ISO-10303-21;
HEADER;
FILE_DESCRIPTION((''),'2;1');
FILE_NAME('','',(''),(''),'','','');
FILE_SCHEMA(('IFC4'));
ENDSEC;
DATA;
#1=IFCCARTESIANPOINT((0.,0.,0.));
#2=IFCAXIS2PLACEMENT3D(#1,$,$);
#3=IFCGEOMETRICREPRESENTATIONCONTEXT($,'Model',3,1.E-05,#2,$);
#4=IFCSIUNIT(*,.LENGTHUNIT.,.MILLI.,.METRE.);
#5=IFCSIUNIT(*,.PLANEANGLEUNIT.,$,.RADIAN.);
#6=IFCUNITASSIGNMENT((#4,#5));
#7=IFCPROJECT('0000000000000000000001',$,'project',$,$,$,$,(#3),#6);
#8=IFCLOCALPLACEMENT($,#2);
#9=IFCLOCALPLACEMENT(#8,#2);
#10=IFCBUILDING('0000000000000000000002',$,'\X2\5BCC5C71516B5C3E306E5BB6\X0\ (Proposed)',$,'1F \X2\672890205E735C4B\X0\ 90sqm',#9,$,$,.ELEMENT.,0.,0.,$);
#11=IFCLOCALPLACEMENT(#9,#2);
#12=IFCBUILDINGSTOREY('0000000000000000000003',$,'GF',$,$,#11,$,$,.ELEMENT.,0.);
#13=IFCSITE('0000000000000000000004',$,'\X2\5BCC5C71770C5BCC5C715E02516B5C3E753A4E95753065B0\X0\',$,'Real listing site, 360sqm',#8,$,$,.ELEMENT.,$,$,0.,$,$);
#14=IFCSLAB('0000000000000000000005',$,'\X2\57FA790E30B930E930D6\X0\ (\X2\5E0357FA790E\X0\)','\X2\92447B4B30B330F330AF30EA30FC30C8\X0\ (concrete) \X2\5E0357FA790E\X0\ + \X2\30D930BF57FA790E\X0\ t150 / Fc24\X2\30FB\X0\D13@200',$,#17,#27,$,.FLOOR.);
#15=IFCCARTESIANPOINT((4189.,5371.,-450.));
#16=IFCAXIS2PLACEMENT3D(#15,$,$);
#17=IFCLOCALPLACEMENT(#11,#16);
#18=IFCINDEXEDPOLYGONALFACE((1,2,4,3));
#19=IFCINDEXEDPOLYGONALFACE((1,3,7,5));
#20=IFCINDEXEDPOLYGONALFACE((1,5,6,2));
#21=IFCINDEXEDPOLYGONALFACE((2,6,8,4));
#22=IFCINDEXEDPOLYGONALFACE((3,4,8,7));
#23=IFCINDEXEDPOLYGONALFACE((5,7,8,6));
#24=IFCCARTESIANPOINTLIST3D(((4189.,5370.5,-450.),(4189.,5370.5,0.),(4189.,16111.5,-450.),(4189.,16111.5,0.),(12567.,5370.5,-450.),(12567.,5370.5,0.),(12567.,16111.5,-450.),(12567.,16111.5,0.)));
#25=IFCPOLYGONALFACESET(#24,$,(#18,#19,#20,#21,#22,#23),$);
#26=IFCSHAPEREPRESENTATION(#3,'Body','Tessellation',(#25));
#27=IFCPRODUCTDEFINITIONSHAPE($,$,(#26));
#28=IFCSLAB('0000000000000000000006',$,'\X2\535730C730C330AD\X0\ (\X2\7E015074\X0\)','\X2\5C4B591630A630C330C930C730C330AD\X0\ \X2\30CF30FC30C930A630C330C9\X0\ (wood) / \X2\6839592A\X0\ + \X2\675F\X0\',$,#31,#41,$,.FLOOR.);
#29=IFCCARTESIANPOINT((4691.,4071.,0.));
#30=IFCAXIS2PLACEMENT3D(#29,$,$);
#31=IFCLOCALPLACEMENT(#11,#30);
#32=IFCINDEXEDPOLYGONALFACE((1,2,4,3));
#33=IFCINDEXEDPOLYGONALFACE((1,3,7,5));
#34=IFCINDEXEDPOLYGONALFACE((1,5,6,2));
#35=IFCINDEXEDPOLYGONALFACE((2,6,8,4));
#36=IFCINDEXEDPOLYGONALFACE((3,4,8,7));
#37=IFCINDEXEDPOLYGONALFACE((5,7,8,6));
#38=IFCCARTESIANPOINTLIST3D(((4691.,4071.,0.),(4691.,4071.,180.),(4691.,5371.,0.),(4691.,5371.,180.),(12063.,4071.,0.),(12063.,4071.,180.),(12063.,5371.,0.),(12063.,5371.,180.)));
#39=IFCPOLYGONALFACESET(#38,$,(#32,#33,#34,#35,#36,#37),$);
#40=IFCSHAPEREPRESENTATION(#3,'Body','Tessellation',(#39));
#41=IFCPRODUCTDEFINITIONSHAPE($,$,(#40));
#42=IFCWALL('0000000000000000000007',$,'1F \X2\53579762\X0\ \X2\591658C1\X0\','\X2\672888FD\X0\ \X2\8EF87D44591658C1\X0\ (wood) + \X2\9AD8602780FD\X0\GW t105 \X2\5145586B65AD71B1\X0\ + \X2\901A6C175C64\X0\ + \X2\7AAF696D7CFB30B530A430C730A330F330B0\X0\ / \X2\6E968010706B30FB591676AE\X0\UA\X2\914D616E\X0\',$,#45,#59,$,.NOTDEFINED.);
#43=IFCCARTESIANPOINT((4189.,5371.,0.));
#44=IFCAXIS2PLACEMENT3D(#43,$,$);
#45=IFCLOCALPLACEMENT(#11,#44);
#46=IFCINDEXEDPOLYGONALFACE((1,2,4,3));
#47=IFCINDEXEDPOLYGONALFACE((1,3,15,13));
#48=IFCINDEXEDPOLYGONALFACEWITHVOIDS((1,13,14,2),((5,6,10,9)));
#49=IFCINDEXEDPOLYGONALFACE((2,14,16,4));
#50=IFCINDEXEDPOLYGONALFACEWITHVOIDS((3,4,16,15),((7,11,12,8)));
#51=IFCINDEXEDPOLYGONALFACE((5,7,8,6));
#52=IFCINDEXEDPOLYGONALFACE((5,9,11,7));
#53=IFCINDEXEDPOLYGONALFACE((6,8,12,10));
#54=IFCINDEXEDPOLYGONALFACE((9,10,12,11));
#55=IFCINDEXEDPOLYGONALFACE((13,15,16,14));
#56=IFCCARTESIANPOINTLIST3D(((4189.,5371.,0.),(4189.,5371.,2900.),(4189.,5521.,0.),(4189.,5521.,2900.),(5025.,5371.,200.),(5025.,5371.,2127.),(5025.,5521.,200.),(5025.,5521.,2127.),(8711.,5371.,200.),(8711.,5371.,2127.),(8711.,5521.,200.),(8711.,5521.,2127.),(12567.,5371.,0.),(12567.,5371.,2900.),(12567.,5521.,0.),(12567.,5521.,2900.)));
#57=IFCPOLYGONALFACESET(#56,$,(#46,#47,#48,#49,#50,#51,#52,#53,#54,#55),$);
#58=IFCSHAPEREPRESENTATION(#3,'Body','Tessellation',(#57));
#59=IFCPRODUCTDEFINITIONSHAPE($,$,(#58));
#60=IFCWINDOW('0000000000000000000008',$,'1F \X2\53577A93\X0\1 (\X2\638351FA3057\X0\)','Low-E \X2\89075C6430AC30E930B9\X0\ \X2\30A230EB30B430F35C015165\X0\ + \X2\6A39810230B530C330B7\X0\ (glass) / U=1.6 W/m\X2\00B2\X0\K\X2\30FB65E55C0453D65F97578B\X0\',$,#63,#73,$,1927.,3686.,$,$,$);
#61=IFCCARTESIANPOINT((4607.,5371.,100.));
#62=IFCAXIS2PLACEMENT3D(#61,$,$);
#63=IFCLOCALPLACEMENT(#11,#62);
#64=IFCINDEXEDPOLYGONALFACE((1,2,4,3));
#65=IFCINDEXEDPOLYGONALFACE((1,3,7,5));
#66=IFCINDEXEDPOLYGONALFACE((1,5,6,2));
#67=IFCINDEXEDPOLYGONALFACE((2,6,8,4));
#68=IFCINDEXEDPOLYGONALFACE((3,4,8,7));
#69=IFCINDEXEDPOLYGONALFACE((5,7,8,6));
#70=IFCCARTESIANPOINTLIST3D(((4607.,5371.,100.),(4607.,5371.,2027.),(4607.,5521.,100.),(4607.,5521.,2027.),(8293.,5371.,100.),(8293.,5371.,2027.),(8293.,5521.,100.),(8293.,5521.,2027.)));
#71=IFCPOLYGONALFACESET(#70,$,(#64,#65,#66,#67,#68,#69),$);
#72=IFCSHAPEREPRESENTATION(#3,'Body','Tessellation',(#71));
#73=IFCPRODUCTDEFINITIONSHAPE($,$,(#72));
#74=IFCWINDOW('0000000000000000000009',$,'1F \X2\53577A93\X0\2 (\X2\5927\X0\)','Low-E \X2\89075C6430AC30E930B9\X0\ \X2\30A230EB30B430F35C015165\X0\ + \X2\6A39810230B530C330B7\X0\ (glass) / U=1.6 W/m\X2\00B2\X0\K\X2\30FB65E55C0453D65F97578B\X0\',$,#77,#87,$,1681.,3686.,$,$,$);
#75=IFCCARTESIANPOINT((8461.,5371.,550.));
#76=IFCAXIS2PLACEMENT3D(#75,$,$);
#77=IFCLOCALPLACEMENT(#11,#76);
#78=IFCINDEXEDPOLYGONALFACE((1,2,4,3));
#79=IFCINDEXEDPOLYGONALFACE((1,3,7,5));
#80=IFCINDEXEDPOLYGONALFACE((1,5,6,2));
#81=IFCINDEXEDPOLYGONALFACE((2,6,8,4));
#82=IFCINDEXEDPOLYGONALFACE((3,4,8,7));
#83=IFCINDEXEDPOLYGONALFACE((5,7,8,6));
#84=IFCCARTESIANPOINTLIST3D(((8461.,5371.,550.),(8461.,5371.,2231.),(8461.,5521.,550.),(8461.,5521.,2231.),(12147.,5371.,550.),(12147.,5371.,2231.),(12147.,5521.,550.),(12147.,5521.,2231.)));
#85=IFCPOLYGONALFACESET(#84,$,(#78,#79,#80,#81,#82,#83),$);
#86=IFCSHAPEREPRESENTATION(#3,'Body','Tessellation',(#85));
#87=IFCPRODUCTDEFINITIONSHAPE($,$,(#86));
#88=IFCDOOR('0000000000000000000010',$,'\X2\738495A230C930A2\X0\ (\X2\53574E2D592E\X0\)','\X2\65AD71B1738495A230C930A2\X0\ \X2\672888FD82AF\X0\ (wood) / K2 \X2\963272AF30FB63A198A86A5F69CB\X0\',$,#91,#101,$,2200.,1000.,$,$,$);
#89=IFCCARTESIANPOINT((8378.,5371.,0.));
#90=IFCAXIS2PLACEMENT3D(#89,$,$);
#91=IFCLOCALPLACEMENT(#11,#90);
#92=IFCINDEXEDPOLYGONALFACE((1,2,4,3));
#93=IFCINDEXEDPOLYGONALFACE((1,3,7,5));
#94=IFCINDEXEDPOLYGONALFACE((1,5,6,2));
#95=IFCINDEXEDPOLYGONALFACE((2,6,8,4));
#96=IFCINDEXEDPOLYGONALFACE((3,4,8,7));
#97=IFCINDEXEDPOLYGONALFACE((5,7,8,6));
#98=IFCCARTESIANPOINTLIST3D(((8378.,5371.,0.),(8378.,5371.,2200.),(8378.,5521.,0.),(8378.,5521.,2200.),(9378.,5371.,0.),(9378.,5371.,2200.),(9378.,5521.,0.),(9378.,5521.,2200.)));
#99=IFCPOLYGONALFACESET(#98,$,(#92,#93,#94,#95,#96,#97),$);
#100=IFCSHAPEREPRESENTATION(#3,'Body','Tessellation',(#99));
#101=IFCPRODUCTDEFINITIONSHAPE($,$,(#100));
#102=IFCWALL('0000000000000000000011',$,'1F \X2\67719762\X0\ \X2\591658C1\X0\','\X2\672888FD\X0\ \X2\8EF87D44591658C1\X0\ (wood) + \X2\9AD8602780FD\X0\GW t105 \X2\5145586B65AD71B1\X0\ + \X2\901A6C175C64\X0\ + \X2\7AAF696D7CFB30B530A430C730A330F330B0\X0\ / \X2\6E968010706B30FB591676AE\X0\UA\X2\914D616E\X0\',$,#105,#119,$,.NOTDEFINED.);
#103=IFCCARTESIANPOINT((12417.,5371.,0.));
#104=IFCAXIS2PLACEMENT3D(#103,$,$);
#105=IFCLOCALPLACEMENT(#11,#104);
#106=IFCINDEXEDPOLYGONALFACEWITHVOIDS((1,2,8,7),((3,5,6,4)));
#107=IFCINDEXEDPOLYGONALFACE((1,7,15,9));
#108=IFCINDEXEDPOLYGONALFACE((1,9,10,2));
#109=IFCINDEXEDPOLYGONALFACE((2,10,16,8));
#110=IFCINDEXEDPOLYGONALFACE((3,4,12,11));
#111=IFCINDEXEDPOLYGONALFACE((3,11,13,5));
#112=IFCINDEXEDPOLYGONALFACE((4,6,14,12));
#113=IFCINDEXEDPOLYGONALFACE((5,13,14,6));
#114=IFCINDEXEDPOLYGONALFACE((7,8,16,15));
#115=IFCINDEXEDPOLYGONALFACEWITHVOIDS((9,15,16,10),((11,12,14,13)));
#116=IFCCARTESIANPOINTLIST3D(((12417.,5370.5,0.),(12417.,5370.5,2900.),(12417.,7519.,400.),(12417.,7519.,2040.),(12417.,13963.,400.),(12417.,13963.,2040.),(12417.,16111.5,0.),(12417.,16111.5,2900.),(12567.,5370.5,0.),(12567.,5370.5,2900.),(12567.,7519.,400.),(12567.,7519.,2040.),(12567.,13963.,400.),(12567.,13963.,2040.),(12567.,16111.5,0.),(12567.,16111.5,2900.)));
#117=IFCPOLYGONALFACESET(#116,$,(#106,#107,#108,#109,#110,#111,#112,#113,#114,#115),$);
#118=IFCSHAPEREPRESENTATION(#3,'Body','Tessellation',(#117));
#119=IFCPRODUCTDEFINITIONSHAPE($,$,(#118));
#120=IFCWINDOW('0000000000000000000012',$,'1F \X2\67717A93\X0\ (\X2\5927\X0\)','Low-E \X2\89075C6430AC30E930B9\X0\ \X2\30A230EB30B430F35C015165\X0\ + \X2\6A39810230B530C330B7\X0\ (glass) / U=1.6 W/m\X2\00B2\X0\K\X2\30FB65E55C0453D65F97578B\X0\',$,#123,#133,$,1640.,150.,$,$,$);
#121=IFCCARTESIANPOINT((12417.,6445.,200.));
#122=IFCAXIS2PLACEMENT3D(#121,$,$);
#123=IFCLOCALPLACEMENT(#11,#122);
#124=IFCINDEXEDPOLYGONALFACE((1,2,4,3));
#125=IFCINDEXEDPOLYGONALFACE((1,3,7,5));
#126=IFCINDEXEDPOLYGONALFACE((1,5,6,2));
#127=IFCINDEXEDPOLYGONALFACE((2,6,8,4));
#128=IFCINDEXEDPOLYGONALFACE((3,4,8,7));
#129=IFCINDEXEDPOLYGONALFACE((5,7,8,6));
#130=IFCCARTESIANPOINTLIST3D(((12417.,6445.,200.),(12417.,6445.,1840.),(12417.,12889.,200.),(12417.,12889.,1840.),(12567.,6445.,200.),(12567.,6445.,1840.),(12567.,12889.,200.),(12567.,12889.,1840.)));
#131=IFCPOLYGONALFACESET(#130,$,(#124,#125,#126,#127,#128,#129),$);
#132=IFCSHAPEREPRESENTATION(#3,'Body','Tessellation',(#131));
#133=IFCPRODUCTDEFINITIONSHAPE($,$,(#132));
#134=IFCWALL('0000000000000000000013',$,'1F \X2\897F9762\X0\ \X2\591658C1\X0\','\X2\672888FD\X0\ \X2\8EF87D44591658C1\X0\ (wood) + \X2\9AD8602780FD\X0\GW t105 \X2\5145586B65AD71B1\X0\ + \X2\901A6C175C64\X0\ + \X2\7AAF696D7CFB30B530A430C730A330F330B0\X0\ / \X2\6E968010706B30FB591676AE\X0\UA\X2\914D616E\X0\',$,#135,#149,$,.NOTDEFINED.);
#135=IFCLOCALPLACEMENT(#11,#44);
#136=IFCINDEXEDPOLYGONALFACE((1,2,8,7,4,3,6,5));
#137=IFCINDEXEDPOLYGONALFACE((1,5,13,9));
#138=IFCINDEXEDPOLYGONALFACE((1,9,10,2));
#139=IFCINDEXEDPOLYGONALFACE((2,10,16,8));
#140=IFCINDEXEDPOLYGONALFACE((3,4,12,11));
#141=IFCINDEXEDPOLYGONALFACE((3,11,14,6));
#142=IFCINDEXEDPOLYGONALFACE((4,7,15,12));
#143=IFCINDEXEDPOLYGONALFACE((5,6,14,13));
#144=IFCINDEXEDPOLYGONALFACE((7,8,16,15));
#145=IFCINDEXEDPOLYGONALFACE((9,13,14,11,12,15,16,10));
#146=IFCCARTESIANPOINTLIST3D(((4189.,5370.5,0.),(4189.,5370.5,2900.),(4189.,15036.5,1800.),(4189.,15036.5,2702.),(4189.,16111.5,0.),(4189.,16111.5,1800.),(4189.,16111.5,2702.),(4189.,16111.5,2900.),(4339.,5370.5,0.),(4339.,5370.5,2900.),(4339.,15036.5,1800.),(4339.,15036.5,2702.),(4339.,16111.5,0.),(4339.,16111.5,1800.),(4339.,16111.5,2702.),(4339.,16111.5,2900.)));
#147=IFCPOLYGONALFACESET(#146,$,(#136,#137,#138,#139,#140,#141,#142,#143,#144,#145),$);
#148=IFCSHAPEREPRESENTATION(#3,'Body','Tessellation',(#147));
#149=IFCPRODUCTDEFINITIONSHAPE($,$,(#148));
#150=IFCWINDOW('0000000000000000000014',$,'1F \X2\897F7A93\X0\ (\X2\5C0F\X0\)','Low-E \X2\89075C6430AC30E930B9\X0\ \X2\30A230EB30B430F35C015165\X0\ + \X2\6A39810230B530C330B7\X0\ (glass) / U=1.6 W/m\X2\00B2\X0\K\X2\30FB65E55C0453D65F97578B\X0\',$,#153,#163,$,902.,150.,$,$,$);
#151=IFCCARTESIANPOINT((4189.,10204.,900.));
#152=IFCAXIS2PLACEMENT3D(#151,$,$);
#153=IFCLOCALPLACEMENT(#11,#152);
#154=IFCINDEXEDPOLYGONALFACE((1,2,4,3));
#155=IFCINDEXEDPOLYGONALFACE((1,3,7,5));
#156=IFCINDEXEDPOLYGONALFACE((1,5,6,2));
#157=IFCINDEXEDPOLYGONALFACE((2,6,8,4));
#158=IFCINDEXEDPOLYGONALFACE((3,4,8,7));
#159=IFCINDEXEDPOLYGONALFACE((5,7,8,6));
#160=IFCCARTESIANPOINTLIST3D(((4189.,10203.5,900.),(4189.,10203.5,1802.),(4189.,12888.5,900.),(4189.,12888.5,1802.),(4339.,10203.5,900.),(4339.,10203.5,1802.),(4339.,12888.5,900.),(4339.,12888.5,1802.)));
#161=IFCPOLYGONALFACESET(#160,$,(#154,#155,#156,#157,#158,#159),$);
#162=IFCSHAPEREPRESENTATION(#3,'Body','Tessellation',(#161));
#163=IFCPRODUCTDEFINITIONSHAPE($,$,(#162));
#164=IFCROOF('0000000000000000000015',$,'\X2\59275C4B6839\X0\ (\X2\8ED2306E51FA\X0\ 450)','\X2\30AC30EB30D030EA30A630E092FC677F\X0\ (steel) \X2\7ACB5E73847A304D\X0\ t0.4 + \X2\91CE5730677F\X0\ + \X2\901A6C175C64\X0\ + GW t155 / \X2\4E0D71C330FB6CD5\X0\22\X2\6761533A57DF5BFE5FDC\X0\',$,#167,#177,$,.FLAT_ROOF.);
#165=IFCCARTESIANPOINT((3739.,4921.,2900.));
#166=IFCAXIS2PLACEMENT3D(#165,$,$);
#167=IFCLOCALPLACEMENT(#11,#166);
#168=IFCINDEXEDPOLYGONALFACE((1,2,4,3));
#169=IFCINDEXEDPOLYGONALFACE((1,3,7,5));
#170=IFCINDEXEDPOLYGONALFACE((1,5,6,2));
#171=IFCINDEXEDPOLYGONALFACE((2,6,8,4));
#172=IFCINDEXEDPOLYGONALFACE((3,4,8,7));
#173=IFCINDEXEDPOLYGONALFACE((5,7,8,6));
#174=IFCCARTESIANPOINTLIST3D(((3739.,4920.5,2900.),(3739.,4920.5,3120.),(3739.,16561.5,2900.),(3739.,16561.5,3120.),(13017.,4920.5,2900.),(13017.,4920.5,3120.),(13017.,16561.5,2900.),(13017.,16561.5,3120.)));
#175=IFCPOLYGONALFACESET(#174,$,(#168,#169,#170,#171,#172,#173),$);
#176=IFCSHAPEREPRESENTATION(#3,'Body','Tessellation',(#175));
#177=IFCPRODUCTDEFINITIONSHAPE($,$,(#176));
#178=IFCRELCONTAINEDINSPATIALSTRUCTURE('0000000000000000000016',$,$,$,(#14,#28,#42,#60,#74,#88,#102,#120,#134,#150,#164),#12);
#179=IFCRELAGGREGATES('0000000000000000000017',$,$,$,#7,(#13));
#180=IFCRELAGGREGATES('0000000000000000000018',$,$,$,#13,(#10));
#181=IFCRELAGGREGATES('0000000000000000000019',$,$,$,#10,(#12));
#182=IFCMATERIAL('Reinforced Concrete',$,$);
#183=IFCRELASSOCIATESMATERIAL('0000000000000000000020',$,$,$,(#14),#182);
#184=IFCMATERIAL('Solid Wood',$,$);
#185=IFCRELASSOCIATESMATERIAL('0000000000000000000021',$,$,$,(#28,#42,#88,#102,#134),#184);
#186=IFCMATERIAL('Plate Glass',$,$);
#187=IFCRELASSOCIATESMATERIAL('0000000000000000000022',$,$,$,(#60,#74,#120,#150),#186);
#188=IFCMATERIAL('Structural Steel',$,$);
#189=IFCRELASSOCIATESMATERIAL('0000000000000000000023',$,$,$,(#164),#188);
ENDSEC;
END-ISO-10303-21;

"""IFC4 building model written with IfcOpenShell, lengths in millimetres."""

from ifc_helpers import new_model, si_unit, frame, frame_2d, origin, place, context, project, spatial, rectangle, extrude, material, element, fill, save


model = new_model("IFC4")

# Units and contexts
model_context = context("Model", 3, precision=1e-05, world=origin())
ifc_project = project(units=[si_unit("LENGTHUNIT", "METRE", prefix="MILLI"), si_unit("PLANEANGLEUNIT", "RADIAN")], contexts=[model_context])

# Site, building, storey
site_placement = place(None, origin())
site = spatial("IfcSite", under=ifc_project, at=site_placement, Name="富山県富山市八尾町井田新", ObjectType="Real listing site, 360sqm", CompositionType="ELEMENT", RefElevation=0.0)
building_placement = place(site_placement, origin())
building = spatial("IfcBuilding", under=site, at=building_placement, Name="富山八尾の家 (Proposed)", ObjectType="1F 木造平屋 90sqm", CompositionType="ELEMENT", ElevationOfRefHeight=0.0, ElevationOfTerrain=0.0)
storey_placement = place(building_placement, origin())
storey = spatial("IfcBuildingStorey", under=building, at=storey_placement, Name="GF", CompositionType="ELEMENT", Elevation=0.0)

# Slabs
ifc_material_1 = material(Name="Reinforced Concrete")
slab_1_placement = place(storey_placement, frame((4189.0, 5371.0, -450.0)))
element("IfcSlab", 1, at=slab_1_placement, inside=storey, material=ifc_material_1, Name="基礎スラブ (布基礎)", Description="鉄筋コンクリート (concrete) 布基礎 + ベタ基礎 t150 / Fc24・D13@200", PredefinedType="FLOOR", context=model_context, shape_type="SweptSolid", body=[
    extrude(rectangle(XDim=8378.0, YDim=10741.0, at=frame_2d((4189.0, 5370.0))), frame((4189.0, 5371.0, -450.0)), (0.0, 0.0, 1.0), 450.0),
])
ifc_material_2 = material(Name="Solid Wood")
slab_2_placement = place(storey_placement, frame((4691.0, 4071.0, 0.0)))
element("IfcSlab", 2, at=slab_2_placement, inside=storey, material=ifc_material_2, Name="南デッキ (縁側)", Description="屋外ウッドデッキ ハードウッド (wood) / 根太 + 束", PredefinedType="FLOOR", context=model_context, shape_type="SweptSolid", body=[
    extrude(rectangle(XDim=7372.0, YDim=1300.0, at=frame_2d((3686.0, 650.0))), frame((4691.0, 4071.0, 0.0)), (0.0, 0.0, 1.0), 180.0),
])

# Wall, openings, windows, door
wall_1_placement = place(storey_placement, frame((4189.0, 5371.0, 0.0)))
wall_1 = element("IfcWall", 3, at=wall_1_placement, inside=storey, material=ifc_material_2, Name="1F 南面 外壁", Description="木製 軸組外壁 (wood) + 高性能GW t105 充填断熱 + 通気層 + 窯業系サイディング / 準耐火・外皮UA配慮", PredefinedType="NOTDEFINED", context=model_context, shape_type="SweptSolid", body=[
    extrude(rectangle(XDim=8378.0, YDim=150.0, at=frame_2d((4189.0, 75.0))), frame((4189.0, 5371.0, 0.0)), (0.0, 0.0, 1.0), 2900.0),
])
opening_1_placement = place(storey_placement, frame((4607.0, 5371.0, 100.0)))
opening_1 = element("IfcOpeningElement", 4, at=opening_1_placement, cuts=wall_1, PredefinedType="NOTDEFINED", context=model_context, shape_type="SweptSolid", body=[
    extrude(rectangle(XDim=3686.0, YDim=150.0, at=frame_2d((1843.0, 75.0))), frame((4607.0, 5371.0, 100.0)), (0.0, 0.0, 1.0), 1927.0),
])
opening_2_placement = place(storey_placement, frame((8461.0, 5371.0, 550.0)))
opening_2 = element("IfcOpeningElement", 5, at=opening_2_placement, cuts=wall_1, PredefinedType="NOTDEFINED", context=model_context, shape_type="SweptSolid", body=[
    extrude(rectangle(XDim=3686.0, YDim=150.0, at=frame_2d((1843.0, 75.0))), frame((8461.0, 5371.0, 550.0)), (0.0, 0.0, 1.0), 1681.0),
])
opening_3_placement = place(storey_placement, frame((8378.0, 5371.0, 0.0)))
opening_3 = element("IfcOpeningElement", 6, at=opening_3_placement, cuts=wall_1, PredefinedType="NOTDEFINED", context=model_context, shape_type="SweptSolid", body=[
    extrude(rectangle(XDim=1000.0, YDim=150.0, at=frame_2d((500.0, 75.0))), frame((8378.0, 5371.0, 0.0)), (0.0, 0.0, 1.0), 2200.0),
])
ifc_material_3 = material(Name="Plate Glass")
window_1_placement = place(storey_placement, frame((4607.0, 5371.0, 100.0)))
window_1 = element("IfcWindow", 7, at=window_1_placement, inside=storey, material=ifc_material_3, Name="1F 南窓1 (掃出し)", Description="Low-E 複層ガラス アルゴン封入 + 樹脂サッシ (glass) / U=1.6 W/m²K・日射取得型", OverallHeight=1927.0, OverallWidth=3686.0, context=model_context, shape_type="SweptSolid", body=[
    extrude(rectangle(XDim=3686.0, YDim=150.0, at=frame_2d((1843.0, 75.0))), frame((4607.0, 5371.0, 100.0)), (0.0, 0.0, 1.0), 1927.0),
])
fill(opening_1, window_1)
window_2_placement = place(storey_placement, frame((8461.0, 5371.0, 550.0)))
window_2 = element("IfcWindow", 8, at=window_2_placement, inside=storey, material=ifc_material_3, Name="1F 南窓2 (大)", Description="Low-E 複層ガラス アルゴン封入 + 樹脂サッシ (glass) / U=1.6 W/m²K・日射取得型", OverallHeight=1681.0, OverallWidth=3686.0, context=model_context, shape_type="SweptSolid", body=[
    extrude(rectangle(XDim=3686.0, YDim=150.0, at=frame_2d((1843.0, 75.0))), frame((8461.0, 5371.0, 550.0)), (0.0, 0.0, 1.0), 1681.0),
])
fill(opening_2, window_2)
door_placement = place(storey_placement, frame((8378.0, 5371.0, 0.0)))
door = element("IfcDoor", 9, at=door_placement, inside=storey, material=ifc_material_2, Name="玄関ドア (南中央)", Description="断熱玄関ドア 木製芯 (wood) / K2 防犯・採風機構", OverallHeight=2200.0, OverallWidth=1000.0, context=model_context, shape_type="SweptSolid", body=[
    extrude(rectangle(XDim=1000.0, YDim=150.0, at=frame_2d((500.0, 75.0))), frame((8378.0, 5371.0, 0.0)), (0.0, 0.0, 1.0), 2200.0),
])
fill(opening_3, door)

# Walls, openings, windows
wall_2_placement = place(storey_placement, frame((12417.0, 5371.0, 0.0)))
wall_2 = element("IfcWall", 10, at=wall_2_placement, inside=storey, material=ifc_material_2, Name="1F 東面 外壁", Description="木製 軸組外壁 (wood) + 高性能GW t105 充填断熱 + 通気層 + 窯業系サイディング / 準耐火・外皮UA配慮", PredefinedType="NOTDEFINED", context=model_context, shape_type="SweptSolid", body=[
    extrude(rectangle(XDim=150.0, YDim=10741.0, at=frame_2d((75.0, 5370.0))), frame((12417.0, 5371.0, 0.0)), (0.0, 0.0, 1.0), 2900.0),
])
opening_4_placement = place(storey_placement, frame((12417.0, 6445.0, 200.0)))
opening_4 = element("IfcOpeningElement", 11, at=opening_4_placement, cuts=wall_2, PredefinedType="NOTDEFINED", context=model_context, shape_type="SweptSolid", body=[
    extrude(rectangle(XDim=150.0, YDim=6444.0, at=frame_2d((75.0, 3222.0))), frame((12417.0, 6445.0, 200.0)), (0.0, 0.0, 1.0), 1640.0),
])
window_3_placement = place(storey_placement, frame((12417.0, 6445.0, 200.0)))
window_3 = element("IfcWindow", 12, at=window_3_placement, inside=storey, material=ifc_material_3, Name="1F 東窓 (大)", Description="Low-E 複層ガラス アルゴン封入 + 樹脂サッシ (glass) / U=1.6 W/m²K・日射取得型", OverallHeight=1640.0, OverallWidth=150.0, context=model_context, shape_type="SweptSolid", body=[
    extrude(rectangle(XDim=150.0, YDim=6444.0, at=frame_2d((75.0, 3222.0))), frame((12417.0, 6445.0, 200.0)), (0.0, 0.0, 1.0), 1640.0),
])
fill(opening_4, window_3)
wall_3_placement = place(storey_placement, frame((4189.0, 5371.0, 0.0)))
wall_3 = element("IfcWall", 13, at=wall_3_placement, inside=storey, material=ifc_material_2, Name="1F 西面 外壁", Description="木製 軸組外壁 (wood) + 高性能GW t105 充填断熱 + 通気層 + 窯業系サイディング / 準耐火・外皮UA配慮", PredefinedType="NOTDEFINED", context=model_context, shape_type="SweptSolid", body=[
    extrude(rectangle(XDim=150.0, YDim=10741.0, at=frame_2d((75.0, 5370.0))), frame((4189.0, 5371.0, 0.0)), (0.0, 0.0, 1.0), 2900.0),
])
opening_5_placement = place(storey_placement, frame((4189.0, 10204.0, 900.0)))
opening_5 = element("IfcOpeningElement", 14, at=opening_5_placement, cuts=wall_3, PredefinedType="NOTDEFINED", context=model_context, shape_type="SweptSolid", body=[
    extrude(rectangle(XDim=150.0, YDim=2685.0, at=frame_2d((75.0, 1342.0))), frame((4189.0, 10204.0, 900.0)), (0.0, 0.0, 1.0), 902.0),
])
window_4_placement = place(storey_placement, frame((4189.0, 10204.0, 900.0)))
window_4 = element("IfcWindow", 15, at=window_4_placement, inside=storey, material=ifc_material_3, Name="1F 西窓 (小)", Description="Low-E 複層ガラス アルゴン封入 + 樹脂サッシ (glass) / U=1.6 W/m²K・日射取得型", OverallHeight=902.0, OverallWidth=150.0, context=model_context, shape_type="SweptSolid", body=[
    extrude(rectangle(XDim=150.0, YDim=2685.0, at=frame_2d((75.0, 1342.0))), frame((4189.0, 10204.0, 900.0)), (0.0, 0.0, 1.0), 902.0),
])
fill(opening_5, window_4)

# Roof
ifc_material_4 = material(Name="Structural Steel")
roof_placement = place(storey_placement, frame((3739.0, 4921.0, 2900.0)))
element("IfcRoof", 16, at=roof_placement, inside=storey, material=ifc_material_4, Name="大屋根 (軒の出 450)", Description="ガルバリウム鋼板 (steel) 立平葺き t0.4 + 野地板 + 通気層 + GW t155 / 不燃・法22条区域対応", PredefinedType="FLAT_ROOF", context=model_context, shape_type="SweptSolid", body=[
    extrude(rectangle(XDim=9278.0, YDim=11641.0, at=frame_2d((4639.0, 5820.0))), frame((3739.0, 4921.0, 2900.0)), (0.0, 0.0, 1.0), 220.0),
])

save(model, "model.ifc")
